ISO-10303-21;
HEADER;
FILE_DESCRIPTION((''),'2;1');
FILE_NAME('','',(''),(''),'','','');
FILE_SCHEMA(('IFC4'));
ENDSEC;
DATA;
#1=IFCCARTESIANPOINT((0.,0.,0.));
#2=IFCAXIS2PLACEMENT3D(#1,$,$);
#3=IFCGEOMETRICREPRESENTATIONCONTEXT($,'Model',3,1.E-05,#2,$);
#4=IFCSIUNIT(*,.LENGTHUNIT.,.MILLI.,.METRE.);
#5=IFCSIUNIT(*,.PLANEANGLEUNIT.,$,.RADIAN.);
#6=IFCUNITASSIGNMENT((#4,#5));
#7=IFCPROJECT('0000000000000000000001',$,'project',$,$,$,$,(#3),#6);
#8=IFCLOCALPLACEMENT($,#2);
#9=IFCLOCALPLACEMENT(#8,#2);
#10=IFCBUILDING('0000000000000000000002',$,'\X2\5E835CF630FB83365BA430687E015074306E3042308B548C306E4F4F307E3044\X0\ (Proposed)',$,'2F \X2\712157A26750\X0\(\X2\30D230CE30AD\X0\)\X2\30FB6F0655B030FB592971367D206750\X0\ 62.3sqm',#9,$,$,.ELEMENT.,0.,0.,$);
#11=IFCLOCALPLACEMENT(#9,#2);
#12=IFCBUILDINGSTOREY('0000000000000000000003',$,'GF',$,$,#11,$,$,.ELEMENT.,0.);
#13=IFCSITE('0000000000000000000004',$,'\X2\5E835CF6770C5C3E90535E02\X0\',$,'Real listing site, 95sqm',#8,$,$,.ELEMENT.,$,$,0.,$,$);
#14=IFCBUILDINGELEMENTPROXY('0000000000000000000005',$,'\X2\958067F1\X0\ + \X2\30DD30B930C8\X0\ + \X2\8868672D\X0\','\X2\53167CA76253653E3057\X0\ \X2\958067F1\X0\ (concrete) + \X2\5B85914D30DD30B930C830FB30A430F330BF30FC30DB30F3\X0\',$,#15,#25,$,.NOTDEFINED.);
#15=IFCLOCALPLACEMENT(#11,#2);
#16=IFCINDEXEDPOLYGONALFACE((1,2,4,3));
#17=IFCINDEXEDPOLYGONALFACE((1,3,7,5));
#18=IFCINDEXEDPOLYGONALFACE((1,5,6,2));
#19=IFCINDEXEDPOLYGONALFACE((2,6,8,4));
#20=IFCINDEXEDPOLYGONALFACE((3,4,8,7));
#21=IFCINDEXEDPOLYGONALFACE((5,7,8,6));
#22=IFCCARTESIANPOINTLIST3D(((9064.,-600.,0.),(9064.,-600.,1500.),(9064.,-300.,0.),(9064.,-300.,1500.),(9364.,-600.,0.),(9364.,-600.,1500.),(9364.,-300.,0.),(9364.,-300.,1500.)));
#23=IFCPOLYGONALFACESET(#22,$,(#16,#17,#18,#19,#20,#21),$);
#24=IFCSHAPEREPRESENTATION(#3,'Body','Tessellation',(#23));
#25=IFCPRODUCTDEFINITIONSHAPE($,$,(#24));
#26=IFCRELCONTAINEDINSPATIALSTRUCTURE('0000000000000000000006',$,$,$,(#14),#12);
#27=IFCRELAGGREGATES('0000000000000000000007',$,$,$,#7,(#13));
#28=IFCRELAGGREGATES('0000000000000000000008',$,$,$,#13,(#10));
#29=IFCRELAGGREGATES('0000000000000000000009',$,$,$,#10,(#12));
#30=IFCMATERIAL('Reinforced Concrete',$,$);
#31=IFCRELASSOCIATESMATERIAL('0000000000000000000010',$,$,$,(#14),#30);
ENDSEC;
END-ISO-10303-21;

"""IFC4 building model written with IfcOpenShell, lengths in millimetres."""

from ifc_helpers import new_model, si_unit, frame, frame_2d, origin, place, context, project, spatial, rectangle, extrude, material, element, save


model = new_model("IFC4")

# Units and contexts
model_context = context("Model", 3, precision=1e-05, world=origin())
ifc_project = project(units=[si_unit("LENGTHUNIT", "METRE", prefix="MILLI"), si_unit("PLANEANGLEUNIT", "RADIAN")], contexts=[model_context])

# Site, building, storey
site_placement = place(None, origin())
site = spatial("IfcSite", under=ifc_project, at=site_placement, Name="広島県尾道市", ObjectType="Real listing site, 95sqm", CompositionType="ELEMENT", RefElevation=0.0)
building_placement = place(site_placement, origin())
building = spatial("IfcBuilding", under=site, at=building_placement, Name="広島・茶室と縁側のある和の住まい (Proposed)", ObjectType="2F 無垢材(ヒノキ)・漆喰・天然素材 62.3sqm", CompositionType="ELEMENT", ElevationOfRefHeight=0.0, ElevationOfTerrain=0.0)
storey_placement = place(building_placement, origin())
storey = spatial("IfcBuildingStorey", under=building, at=storey_placement, Name="GF", CompositionType="ELEMENT", Elevation=0.0)

# Shared definitions
ifc_material_1 = material(Name="Reinforced Concrete")

# Building element proxy
proxy_placement = place(storey_placement, frame((4532.0, -300.0, 0.0)))
element("IfcBuildingElementProxy", 1, at=proxy_placement, inside=storey, material=ifc_material_1, Name="門柱 + ポスト + 表札", Description="化粧打放し 門柱 (concrete) + 宅配ポスト・インターホン", PredefinedType="NOTDEFINED", context=model_context, shape_type="SweptSolid", body=[
    extrude(rectangle(XDim=300.0, YDim=300.0, at=frame_2d((150.0, 150.0))), frame((4532.0, -300.0, 0.0)), (0.0, 0.0, 1.0), 1500.0),
])

save(model, "model.ifc")
